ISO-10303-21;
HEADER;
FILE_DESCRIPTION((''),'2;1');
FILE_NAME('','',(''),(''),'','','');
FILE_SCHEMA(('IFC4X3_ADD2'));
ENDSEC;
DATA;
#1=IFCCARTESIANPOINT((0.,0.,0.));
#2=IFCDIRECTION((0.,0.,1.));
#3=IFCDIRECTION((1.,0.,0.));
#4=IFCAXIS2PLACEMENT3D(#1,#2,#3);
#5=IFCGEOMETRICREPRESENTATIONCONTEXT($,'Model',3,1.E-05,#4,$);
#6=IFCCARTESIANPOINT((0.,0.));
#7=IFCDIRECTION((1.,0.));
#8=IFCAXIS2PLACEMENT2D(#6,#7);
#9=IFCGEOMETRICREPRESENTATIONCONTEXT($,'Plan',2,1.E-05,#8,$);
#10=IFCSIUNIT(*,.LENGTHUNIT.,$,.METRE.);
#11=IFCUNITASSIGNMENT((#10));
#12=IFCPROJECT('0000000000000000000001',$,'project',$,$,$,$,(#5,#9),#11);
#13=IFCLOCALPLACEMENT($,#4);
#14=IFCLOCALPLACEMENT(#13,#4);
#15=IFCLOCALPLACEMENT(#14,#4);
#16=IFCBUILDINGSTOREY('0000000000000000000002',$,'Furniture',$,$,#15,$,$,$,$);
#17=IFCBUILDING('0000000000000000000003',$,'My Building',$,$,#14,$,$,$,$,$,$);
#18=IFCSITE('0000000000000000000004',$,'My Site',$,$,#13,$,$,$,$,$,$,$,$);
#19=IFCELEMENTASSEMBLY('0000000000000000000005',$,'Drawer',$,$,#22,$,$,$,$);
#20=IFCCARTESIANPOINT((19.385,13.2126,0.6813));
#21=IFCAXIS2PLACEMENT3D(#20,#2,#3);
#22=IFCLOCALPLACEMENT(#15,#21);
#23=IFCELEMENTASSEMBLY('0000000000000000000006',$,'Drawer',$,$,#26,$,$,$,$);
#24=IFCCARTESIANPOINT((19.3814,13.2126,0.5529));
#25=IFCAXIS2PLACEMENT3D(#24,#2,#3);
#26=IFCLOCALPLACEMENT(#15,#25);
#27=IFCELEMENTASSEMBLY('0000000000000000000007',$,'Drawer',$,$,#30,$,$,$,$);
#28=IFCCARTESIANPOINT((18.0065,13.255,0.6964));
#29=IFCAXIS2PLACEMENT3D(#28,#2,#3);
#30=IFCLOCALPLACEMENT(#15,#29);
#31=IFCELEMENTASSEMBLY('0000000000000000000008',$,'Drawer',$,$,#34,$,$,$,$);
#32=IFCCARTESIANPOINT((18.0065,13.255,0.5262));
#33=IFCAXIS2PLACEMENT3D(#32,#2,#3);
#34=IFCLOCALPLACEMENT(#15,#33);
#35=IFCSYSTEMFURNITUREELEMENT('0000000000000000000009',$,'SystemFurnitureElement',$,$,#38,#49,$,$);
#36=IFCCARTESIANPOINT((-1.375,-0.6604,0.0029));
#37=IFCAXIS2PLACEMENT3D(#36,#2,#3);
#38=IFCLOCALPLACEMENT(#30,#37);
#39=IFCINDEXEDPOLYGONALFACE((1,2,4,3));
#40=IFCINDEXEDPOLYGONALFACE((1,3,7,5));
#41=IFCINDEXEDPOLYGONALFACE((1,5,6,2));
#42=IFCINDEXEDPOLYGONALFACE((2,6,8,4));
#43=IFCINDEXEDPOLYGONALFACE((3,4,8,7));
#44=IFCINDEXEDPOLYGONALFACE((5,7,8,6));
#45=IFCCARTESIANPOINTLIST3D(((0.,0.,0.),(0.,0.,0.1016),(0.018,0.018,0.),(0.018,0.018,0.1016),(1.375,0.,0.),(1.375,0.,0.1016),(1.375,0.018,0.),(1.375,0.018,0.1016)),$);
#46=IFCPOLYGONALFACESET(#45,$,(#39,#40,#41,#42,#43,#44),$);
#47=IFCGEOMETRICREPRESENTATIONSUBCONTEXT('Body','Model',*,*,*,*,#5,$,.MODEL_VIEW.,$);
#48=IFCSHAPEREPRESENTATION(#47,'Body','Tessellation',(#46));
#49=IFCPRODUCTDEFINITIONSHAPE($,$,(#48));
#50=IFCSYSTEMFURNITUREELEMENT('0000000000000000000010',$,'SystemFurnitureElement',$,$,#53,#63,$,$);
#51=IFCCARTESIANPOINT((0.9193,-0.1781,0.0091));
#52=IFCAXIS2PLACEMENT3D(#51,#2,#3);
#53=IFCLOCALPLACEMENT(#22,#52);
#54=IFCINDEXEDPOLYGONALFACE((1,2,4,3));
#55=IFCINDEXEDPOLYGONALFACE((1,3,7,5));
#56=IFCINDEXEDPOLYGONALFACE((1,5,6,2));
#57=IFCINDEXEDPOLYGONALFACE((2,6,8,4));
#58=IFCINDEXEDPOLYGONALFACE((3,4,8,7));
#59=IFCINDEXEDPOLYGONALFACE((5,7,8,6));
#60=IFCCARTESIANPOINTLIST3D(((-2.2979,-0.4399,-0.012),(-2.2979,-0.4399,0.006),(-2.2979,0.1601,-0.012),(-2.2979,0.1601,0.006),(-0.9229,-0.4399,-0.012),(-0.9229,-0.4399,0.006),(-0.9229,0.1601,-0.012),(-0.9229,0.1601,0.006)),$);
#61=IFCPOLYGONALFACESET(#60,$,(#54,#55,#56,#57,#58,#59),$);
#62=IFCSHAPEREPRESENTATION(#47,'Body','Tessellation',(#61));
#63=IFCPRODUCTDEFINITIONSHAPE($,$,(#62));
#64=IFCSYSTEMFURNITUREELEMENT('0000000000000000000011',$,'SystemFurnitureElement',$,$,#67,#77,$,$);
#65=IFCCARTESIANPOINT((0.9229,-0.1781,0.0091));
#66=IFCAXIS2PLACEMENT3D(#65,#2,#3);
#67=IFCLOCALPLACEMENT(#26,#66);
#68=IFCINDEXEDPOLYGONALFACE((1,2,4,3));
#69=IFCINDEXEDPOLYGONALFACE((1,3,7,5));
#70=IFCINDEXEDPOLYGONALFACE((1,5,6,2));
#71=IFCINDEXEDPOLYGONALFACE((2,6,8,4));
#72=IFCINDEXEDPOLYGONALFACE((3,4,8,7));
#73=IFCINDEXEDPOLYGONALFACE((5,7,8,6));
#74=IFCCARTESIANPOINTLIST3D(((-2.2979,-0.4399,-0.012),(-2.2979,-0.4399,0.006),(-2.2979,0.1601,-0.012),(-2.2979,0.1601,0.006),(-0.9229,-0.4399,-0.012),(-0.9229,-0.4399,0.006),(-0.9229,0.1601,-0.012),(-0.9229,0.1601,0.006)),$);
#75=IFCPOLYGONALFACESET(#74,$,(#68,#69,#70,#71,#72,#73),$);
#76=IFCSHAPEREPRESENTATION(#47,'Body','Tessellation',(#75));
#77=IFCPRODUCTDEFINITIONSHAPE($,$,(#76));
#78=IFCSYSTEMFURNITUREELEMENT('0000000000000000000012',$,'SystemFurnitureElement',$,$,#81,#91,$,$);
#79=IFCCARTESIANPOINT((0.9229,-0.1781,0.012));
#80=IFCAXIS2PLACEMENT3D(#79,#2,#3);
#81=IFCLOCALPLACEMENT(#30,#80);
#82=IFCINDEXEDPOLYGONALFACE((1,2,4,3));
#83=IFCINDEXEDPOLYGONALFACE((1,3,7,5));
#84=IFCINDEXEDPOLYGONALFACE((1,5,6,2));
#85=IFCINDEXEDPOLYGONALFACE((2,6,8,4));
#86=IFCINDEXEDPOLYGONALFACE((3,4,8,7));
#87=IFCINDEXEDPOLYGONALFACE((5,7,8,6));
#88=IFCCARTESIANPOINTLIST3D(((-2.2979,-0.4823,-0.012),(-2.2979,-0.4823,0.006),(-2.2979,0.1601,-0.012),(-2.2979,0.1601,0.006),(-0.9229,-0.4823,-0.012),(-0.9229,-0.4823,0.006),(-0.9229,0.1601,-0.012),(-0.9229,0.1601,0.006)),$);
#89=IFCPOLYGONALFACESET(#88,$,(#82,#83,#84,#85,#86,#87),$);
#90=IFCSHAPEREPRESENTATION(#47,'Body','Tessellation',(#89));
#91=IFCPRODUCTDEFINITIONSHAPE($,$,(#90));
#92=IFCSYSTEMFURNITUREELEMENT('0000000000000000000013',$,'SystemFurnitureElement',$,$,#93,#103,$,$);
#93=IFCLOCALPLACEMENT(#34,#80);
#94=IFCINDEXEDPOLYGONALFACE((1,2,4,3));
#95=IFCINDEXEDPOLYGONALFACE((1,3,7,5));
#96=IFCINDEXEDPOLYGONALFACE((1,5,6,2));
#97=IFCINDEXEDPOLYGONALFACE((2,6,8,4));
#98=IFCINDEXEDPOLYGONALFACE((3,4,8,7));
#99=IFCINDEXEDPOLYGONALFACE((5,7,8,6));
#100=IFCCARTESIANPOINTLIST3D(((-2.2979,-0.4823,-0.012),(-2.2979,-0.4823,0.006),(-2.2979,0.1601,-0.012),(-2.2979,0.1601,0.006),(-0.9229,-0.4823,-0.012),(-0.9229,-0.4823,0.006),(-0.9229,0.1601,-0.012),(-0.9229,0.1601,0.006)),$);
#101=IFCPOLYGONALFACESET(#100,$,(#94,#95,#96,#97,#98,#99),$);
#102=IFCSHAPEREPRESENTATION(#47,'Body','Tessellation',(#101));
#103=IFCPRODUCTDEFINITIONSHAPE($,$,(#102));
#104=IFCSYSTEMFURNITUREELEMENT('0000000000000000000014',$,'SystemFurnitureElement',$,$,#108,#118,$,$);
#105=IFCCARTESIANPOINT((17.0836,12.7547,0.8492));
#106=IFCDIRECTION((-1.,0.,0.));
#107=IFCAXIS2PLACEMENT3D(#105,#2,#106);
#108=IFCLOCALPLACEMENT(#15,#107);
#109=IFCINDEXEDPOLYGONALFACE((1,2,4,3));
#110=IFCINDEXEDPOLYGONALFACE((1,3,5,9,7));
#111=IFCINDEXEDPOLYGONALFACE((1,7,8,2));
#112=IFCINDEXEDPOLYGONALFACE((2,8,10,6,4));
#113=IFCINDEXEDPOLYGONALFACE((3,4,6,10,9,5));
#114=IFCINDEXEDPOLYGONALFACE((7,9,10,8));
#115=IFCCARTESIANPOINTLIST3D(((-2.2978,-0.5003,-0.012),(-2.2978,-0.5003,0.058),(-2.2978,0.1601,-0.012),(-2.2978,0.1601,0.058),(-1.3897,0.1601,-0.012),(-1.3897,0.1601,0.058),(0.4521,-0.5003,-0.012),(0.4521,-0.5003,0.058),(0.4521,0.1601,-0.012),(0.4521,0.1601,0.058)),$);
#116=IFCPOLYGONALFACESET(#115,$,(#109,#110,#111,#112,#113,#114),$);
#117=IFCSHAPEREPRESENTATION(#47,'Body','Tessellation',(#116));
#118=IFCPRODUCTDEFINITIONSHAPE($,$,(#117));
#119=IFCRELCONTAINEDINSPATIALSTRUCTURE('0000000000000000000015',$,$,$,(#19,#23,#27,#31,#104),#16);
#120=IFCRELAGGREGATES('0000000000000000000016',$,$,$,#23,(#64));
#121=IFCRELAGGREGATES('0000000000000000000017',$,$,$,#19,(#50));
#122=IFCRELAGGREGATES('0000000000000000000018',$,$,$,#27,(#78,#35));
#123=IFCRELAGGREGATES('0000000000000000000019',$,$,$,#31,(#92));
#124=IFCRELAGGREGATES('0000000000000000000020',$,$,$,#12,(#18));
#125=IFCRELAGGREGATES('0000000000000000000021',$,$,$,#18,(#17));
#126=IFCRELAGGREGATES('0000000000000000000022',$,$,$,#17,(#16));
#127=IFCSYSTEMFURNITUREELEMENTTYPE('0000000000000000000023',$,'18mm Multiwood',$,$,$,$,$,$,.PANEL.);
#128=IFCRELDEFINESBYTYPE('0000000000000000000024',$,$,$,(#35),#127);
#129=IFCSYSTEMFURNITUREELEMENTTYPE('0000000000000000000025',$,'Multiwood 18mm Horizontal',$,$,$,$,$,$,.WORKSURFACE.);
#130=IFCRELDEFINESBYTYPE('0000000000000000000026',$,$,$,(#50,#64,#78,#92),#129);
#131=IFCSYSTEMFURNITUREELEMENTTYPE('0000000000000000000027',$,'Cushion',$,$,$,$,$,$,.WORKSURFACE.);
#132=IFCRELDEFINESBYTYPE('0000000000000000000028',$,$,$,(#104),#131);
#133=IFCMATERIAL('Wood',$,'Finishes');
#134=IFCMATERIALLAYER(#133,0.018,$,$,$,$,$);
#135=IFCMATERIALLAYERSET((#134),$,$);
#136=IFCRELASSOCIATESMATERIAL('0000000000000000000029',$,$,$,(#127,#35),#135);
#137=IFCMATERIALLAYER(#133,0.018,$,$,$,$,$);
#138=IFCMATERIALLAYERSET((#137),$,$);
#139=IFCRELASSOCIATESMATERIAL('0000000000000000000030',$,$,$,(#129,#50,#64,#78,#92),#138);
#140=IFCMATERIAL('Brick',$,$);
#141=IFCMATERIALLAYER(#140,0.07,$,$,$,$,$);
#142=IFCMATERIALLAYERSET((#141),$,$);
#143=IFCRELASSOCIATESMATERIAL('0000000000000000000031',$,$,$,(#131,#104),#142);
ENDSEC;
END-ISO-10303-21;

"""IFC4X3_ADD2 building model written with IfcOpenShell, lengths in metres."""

from ifc_helpers import new_model, si_unit, frame, origin_with_axes, origin_2d_with_axis, place, context, subcontext, project, spatial, line, indexed_curve, outline, extrude, material, layer, layer_set, layer_usage, type_object, element, aggregate, save


model = new_model("IFC4X3_ADD2")

# Units and contexts
model_context = context("Model", 3, precision=1e-05, world=origin_with_axes())
plan_context = context("Plan", 2, precision=1e-05, world=origin_2d_with_axis())
body_context = subcontext(model_context, "Body", "Model", "MODEL_VIEW")
ifc_project = project(units=[si_unit("LENGTHUNIT", "METRE")], contexts=[model_context, plan_context])

# Site, building, storey
site_placement = place(None, origin_with_axes())
site = spatial("IfcSite", under=ifc_project, at=site_placement, Name="My Site")
building_placement = place(site_placement, origin_with_axes())
building = spatial("IfcBuilding", under=site, at=building_placement, Name="My Building")
storey_placement = place(building_placement, origin_with_axes())
storey = spatial("IfcBuildingStorey", under=building, at=storey_placement, Name="Furniture")

# Shared definitions
ifc_material_1 = material(Name="Wood", Category="Finishes")
ifc_layer_1 = layer(ifc_material_1, 0.018)
ifc_layer_set_1 = layer_set([ifc_layer_1])
system_furniture_element_type_1 = type_object("IfcSystemFurnitureElementType", Name="18mm Multiwood", PredefinedType="PANEL", material=ifc_layer_set_1)

# Element assembly
assembly_1_placement = place(storey_placement, frame((19.385, 13.2126, 0.6813), z_axis=(0.0, 0.0, 1.0), x_axis=(1.0, 0.0, 0.0)))
assembly_1 = element("IfcElementAssembly", 1, at=assembly_1_placement, inside=storey, Name="Drawer")

# Element assembly
assembly_2_placement = place(storey_placement, frame((19.3814, 13.2126, 0.5529), z_axis=(0.0, 0.0, 1.0), x_axis=(1.0, 0.0, 0.0)))
assembly_2 = element("IfcElementAssembly", 2, at=assembly_2_placement, inside=storey, Name="Drawer")

# Element assemblies
assembly_3_placement = place(storey_placement, frame((18.0065, 13.255, 0.6964), z_axis=(0.0, 0.0, 1.0), x_axis=(1.0, 0.0, 0.0)))
assembly_3 = element("IfcElementAssembly", 3, at=assembly_3_placement, inside=storey, Name="Drawer")
assembly_4_placement = place(storey_placement, frame((18.0065, 13.255, 0.5262), z_axis=(0.0, 0.0, 1.0), x_axis=(1.0, 0.0, 0.0)))
assembly_4 = element("IfcElementAssembly", 4, at=assembly_4_placement, inside=storey, Name="Drawer")

# System furniture element
ifc_layer_usage_1 = layer_usage(ifc_layer_set_1, "AXIS2", "POSITIVE", 0.0)
system_furniture_element_1_placement = place(assembly_3_placement, frame((-1.375, -0.6604, 0.0029), z_axis=(0.0, 0.0, 1.0), x_axis=(1.0, 0.0, 0.0)))
system_furniture_element_1 = element("IfcSystemFurnitureElement", 5, at=system_furniture_element_1_placement, type_object=system_furniture_element_type_1, material=ifc_layer_usage_1, Name="SystemFurnitureElement", context=body_context, shape_type="SweptSolid", body=[
    extrude(outline(indexed_curve([(0.0, 0.0), (0.018, 0.018), (1.375, 0.018), (1.375, 0.0)], segments=[line(1, 2, 3, 4, 1)])), origin_with_axes(), (0.0, 0.0, 1.0), 0.1016),
])

# System furniture elements
ifc_layer_2 = layer(ifc_material_1, 0.018)
ifc_layer_set_2 = layer_set([ifc_layer_2])
ifc_layer_usage_2 = layer_usage(ifc_layer_set_2, "AXIS3", "POSITIVE", -0.012)
system_furniture_element_type_2 = type_object("IfcSystemFurnitureElementType", Name="Multiwood 18mm Horizontal", PredefinedType="WORKSURFACE", material=ifc_layer_set_2)
system_furniture_element_2_placement = place(assembly_1_placement, frame((0.9193, -0.1781, 0.0091), z_axis=(0.0, 0.0, 1.0), x_axis=(1.0, 0.0, 0.0)))
system_furniture_element_2 = element("IfcSystemFurnitureElement", 6, at=system_furniture_element_2_placement, type_object=system_furniture_element_type_2, material=ifc_layer_usage_2, Name="SystemFurnitureElement", context=body_context, shape_type="SweptSolid", body=[
    extrude(outline(indexed_curve([(-2.2979, -0.4399), (-2.2979, 0.1601), (-0.9229, 0.1601), (-0.9229, -0.4399), (-2.2979, -0.4399)])), frame((0.0, 0.0, -0.012), z_axis=(0.0, 0.0, 1.0), x_axis=(1.0, 0.0, 0.0)), (0.0, 0.0, 1.0), 0.018),
])
ifc_layer_usage_3 = layer_usage(ifc_layer_set_2, "AXIS3", "POSITIVE", -0.012)
system_furniture_element_3_placement = place(assembly_2_placement, frame((0.9229, -0.1781, 0.0091), z_axis=(0.0, 0.0, 1.0), x_axis=(1.0, 0.0, 0.0)))
system_furniture_element_3 = element("IfcSystemFurnitureElement", 7, at=system_furniture_element_3_placement, type_object=system_furniture_element_type_2, material=ifc_layer_usage_3, Name="SystemFurnitureElement", context=body_context, shape_type="SweptSolid", body=[
    extrude(outline(indexed_curve([(-2.2979, -0.4399), (-2.2979, 0.1601), (-0.9229, 0.1601), (-0.9229, -0.4399), (-2.2979, -0.4399)])), frame((0.0, 0.0, -0.012), z_axis=(0.0, 0.0, 1.0), x_axis=(1.0, 0.0, 0.0)), (0.0, 0.0, 1.0), 0.018),
])
ifc_layer_usage_4 = layer_usage(ifc_layer_set_2, "AXIS3", "POSITIVE", -0.012)
system_furniture_element_4_placement = place(assembly_3_placement, frame((0.9229, -0.1781, 0.012), z_axis=(0.0, 0.0, 1.0), x_axis=(1.0, 0.0, 0.0)))
system_furniture_element_4 = element("IfcSystemFurnitureElement", 8, at=system_furniture_element_4_placement, type_object=system_furniture_element_type_2, material=ifc_layer_usage_4, Name="SystemFurnitureElement", context=body_context, shape_type="SweptSolid", body=[
    extrude(outline(indexed_curve([(-0.9229, -0.4823), (-0.9229, 0.1601), (-2.2979, 0.1601), (-2.2979, -0.4823), (-0.9229, -0.4823)])), frame((0.0, 0.0, -0.012), z_axis=(0.0, 0.0, 1.0), x_axis=(1.0, 0.0, 0.0)), (0.0, 0.0, 1.0), 0.018),
])
ifc_layer_usage_5 = layer_usage(ifc_layer_set_2, "AXIS3", "POSITIVE", -0.012)
system_furniture_element_5_placement = place(assembly_4_placement, frame((0.9229, -0.1781, 0.012), z_axis=(0.0, 0.0, 1.0), x_axis=(1.0, 0.0, 0.0)))
system_furniture_element_5 = element("IfcSystemFurnitureElement", 9, at=system_furniture_element_5_placement, type_object=system_furniture_element_type_2, material=ifc_layer_usage_5, Name="SystemFurnitureElement", context=body_context, shape_type="SweptSolid", body=[
    extrude(outline(indexed_curve([(-0.9229, -0.4823), (-0.9229, 0.1601), (-2.2979, 0.1601), (-2.2979, -0.4823), (-0.9229, -0.4823)])), frame((0.0, 0.0, -0.012), z_axis=(0.0, 0.0, 1.0), x_axis=(1.0, 0.0, 0.0)), (0.0, 0.0, 1.0), 0.018),
])
ifc_material_2 = material(Name="Brick")
ifc_layer_3 = layer(ifc_material_2, 0.07)
ifc_layer_set_3 = layer_set([ifc_layer_3])
ifc_layer_usage_6 = layer_usage(ifc_layer_set_3, "AXIS3", "POSITIVE", -0.012)
system_furniture_element_type_3 = type_object("IfcSystemFurnitureElementType", Name="Cushion", PredefinedType="WORKSURFACE", material=ifc_layer_set_3)
system_furniture_element_6_placement = place(storey_placement, frame((17.0836, 12.7547, 0.8492), z_axis=(0.0, 0.0, 1.0), x_axis=(-1.0, 0.0, 0.0)))
element("IfcSystemFurnitureElement", 10, at=system_furniture_element_6_placement, inside=storey, type_object=system_furniture_element_type_3, material=ifc_layer_usage_6, Name="SystemFurnitureElement", context=body_context, shape_type="SweptSolid", body=[
    extrude(outline(indexed_curve([(0.4521, -0.5003), (0.4521, 0.1601), (-1.3897, 0.1601), (-2.2978, 0.1601), (-2.2978, -0.5003), (0.4521, -0.5003)])), frame((0.0, 0.0, -0.012), z_axis=(0.0, 0.0, 1.0), x_axis=(1.0, 0.0, 0.0)), (0.0, 0.0, 1.0), 0.07),
])
aggregate(assembly_2, [system_furniture_element_3])
aggregate(assembly_1, [system_furniture_element_2])
aggregate(assembly_3, [system_furniture_element_4, system_furniture_element_1])
aggregate(assembly_4, [system_furniture_element_5])

save(model, "model.ifc")
